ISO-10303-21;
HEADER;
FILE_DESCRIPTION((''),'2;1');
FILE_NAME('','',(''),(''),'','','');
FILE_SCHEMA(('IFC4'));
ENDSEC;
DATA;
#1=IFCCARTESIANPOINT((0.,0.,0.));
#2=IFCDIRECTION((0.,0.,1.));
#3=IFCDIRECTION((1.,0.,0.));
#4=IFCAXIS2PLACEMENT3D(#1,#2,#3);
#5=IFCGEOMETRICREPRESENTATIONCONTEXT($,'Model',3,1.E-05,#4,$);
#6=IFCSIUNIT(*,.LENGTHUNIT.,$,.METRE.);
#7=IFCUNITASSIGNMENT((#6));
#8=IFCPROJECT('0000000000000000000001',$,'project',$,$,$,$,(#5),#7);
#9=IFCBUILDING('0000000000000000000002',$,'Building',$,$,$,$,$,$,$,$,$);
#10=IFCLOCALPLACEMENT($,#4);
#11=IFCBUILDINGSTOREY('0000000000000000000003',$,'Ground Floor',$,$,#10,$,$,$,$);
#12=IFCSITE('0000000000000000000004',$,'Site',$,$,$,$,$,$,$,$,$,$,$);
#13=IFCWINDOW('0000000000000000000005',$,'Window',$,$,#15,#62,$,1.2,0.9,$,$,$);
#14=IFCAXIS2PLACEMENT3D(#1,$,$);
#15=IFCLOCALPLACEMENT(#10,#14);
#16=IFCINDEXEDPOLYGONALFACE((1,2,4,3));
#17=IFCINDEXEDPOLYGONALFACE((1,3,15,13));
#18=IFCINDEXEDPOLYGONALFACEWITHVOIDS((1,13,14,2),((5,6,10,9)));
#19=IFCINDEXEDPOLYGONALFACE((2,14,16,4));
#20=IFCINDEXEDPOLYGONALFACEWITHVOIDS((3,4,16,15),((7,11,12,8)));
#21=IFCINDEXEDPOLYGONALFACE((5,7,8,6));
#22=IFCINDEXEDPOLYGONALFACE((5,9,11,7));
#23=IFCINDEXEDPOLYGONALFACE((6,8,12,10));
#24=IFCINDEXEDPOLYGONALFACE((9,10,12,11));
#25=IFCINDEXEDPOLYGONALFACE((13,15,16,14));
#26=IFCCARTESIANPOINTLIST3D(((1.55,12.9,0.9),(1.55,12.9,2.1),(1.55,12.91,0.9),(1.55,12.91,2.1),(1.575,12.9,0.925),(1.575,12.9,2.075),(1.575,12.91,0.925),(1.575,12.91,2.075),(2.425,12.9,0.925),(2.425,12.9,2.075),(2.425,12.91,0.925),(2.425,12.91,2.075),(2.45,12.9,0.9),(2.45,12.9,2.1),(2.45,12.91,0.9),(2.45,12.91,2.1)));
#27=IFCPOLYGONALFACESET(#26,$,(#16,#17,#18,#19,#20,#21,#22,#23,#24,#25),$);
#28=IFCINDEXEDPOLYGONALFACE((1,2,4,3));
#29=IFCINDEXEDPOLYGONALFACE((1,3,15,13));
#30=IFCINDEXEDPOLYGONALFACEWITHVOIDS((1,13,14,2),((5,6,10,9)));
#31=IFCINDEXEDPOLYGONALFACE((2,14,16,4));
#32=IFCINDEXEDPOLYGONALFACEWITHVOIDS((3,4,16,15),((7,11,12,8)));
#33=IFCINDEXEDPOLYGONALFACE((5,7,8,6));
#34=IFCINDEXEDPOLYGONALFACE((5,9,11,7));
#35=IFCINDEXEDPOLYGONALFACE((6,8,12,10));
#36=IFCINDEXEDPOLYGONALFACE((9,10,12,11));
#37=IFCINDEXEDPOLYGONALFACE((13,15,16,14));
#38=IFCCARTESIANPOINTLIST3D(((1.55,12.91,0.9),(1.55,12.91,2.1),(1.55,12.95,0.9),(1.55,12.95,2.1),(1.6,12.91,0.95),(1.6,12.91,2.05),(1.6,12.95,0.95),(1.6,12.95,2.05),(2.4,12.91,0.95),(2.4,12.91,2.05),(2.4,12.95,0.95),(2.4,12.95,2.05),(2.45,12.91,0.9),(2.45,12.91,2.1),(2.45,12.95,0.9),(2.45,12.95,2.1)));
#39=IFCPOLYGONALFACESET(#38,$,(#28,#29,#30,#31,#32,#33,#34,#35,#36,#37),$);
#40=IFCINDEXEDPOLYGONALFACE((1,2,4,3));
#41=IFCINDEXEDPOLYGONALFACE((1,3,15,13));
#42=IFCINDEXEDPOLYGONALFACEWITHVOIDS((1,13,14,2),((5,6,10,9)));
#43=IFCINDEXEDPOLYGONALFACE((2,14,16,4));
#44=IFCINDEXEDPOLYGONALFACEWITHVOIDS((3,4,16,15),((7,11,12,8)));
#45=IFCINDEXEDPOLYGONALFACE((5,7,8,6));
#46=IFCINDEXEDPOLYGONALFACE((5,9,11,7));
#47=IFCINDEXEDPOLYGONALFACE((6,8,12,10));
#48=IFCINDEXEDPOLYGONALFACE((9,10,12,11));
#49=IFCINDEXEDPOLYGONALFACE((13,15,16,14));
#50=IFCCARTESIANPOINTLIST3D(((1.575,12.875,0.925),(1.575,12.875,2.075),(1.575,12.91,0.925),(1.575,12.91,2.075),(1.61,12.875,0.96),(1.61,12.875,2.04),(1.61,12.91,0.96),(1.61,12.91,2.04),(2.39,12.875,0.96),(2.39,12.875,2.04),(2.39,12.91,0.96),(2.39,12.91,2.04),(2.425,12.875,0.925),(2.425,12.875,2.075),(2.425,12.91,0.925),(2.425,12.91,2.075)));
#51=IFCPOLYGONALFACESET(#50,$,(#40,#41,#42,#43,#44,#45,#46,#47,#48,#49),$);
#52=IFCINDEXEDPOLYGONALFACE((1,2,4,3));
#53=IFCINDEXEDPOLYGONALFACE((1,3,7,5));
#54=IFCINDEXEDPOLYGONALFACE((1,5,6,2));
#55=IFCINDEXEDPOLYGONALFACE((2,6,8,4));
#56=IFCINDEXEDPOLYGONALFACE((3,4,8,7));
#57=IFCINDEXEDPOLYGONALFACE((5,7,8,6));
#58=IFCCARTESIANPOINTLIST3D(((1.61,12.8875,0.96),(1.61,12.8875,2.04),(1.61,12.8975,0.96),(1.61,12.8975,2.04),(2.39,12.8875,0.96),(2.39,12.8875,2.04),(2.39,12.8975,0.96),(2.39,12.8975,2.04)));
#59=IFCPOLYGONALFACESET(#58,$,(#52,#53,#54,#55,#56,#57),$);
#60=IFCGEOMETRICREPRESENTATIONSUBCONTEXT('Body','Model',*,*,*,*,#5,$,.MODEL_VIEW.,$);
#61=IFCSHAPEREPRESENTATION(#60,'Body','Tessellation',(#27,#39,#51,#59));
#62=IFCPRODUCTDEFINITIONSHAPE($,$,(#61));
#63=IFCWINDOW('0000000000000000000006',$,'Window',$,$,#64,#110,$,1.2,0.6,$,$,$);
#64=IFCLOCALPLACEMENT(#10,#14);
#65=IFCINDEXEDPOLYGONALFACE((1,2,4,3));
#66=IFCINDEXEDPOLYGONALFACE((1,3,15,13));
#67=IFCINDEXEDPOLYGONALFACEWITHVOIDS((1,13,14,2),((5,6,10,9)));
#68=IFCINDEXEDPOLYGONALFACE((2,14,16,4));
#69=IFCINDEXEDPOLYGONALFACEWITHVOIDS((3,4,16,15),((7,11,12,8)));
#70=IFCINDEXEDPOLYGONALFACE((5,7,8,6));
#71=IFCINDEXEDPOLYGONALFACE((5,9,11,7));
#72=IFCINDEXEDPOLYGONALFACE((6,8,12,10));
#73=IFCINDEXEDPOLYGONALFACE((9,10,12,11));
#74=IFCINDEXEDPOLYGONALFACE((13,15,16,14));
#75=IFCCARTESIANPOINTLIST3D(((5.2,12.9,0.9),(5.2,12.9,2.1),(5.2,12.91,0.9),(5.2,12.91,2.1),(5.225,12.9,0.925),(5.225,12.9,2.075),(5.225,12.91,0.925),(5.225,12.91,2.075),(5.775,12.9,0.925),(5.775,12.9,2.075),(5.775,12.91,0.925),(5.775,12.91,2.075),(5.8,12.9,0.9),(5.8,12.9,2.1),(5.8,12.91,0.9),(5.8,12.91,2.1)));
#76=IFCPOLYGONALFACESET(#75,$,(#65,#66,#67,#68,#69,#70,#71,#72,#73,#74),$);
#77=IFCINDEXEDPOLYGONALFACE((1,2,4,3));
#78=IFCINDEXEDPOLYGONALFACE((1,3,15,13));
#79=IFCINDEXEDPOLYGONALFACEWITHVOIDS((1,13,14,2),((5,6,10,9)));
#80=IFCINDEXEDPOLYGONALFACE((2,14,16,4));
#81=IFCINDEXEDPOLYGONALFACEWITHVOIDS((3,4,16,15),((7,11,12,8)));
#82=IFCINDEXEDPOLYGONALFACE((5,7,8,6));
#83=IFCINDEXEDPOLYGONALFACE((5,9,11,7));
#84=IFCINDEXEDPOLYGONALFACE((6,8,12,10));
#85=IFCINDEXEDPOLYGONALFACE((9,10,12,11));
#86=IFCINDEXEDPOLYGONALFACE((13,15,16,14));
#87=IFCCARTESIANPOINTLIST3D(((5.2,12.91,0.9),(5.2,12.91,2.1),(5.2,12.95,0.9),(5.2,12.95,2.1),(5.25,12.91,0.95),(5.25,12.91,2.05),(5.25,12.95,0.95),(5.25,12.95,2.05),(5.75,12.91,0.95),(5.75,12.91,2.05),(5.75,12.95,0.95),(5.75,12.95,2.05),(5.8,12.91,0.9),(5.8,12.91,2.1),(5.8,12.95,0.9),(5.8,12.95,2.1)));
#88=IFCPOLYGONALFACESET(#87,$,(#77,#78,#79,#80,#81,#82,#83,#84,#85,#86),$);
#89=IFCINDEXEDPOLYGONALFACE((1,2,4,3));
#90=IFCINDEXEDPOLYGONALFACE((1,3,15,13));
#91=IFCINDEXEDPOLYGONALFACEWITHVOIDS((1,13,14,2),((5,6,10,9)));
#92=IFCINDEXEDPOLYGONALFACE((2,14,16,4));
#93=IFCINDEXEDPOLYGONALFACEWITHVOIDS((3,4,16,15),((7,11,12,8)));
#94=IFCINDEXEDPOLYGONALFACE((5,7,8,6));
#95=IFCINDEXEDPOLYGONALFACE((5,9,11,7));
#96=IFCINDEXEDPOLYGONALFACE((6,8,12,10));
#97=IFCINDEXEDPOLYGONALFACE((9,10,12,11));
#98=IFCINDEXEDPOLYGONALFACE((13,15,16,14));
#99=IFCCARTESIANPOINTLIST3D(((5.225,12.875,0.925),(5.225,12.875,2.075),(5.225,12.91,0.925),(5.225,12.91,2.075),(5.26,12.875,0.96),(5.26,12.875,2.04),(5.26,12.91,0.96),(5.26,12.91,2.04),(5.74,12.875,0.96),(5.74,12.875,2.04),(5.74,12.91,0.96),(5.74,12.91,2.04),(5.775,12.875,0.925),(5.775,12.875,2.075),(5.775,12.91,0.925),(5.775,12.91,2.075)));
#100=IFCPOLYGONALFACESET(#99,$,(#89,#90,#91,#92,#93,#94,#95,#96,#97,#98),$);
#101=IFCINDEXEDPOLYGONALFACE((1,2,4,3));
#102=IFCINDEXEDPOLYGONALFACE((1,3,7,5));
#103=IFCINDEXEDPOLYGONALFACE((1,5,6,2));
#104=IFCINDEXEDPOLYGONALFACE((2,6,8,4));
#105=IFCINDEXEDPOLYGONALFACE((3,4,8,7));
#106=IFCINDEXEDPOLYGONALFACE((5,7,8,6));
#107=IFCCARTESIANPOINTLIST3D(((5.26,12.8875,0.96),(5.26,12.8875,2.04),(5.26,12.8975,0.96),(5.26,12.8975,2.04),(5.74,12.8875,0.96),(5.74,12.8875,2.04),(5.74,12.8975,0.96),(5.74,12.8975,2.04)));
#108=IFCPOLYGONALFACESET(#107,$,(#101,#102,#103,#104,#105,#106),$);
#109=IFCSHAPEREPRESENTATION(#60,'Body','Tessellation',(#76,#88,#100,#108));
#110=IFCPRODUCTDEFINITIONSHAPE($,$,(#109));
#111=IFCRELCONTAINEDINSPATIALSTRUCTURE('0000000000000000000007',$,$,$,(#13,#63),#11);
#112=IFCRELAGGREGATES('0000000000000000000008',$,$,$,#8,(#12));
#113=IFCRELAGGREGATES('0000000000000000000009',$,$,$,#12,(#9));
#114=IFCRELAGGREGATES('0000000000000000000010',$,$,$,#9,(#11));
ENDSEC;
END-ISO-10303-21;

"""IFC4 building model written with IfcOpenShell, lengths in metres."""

from ifc_helpers import new_model, si_unit, frame, origin_with_axes, place, context, subcontext, project, spatial, line, indexed_curve, outline, extrude, element, save


model = new_model("IFC4")

# Units and contexts
model_context = context("Model", 3, precision=1e-05, world=origin_with_axes())
body_context = subcontext(model_context, "Body", "Model", "MODEL_VIEW")
ifc_project = project(units=[si_unit("LENGTHUNIT", "METRE")], contexts=[model_context])

# Site, building, storey
site = spatial("IfcSite", under=ifc_project, Name="Site")
building = spatial("IfcBuilding", under=site, Name="Building")
storey_placement = place(None, origin_with_axes())
storey = spatial("IfcBuildingStorey", under=building, at=storey_placement, Name="Ground Floor")

# Windows
for number, where, z_axis, x_axis, name in (
    (1, (2.45, 13.0, 0.9), (0.0, 0.0, 1.0), (-1.0, 0.0, 0.0), "Window"),
):
    element("IfcWindow", number, at=place(storey_placement, frame(where, z_axis=z_axis, x_axis=x_axis)), inside=storey, Name=name, OverallHeight=1.2, OverallWidth=0.9, context=body_context, shape_type="SweptSolid", body=[
        extrude(outline(indexed_curve([(0.0, 0.0), (0.9, 0.0), (0.9, 1.2), (0.0, 1.2)], segments=[line(1, 2, 3, 4, 1)]), holes=[indexed_curve([(0.025, 0.025), (0.875, 0.025), (0.875, 1.175), (0.025, 1.175)], segments=[line(1, 2, 3, 4, 1)])]), frame((0.0, 0.09, 0.0), z_axis=(0.0, -1.0, 0.0), x_axis=(1.0, 0.0, 0.0)), (0.0, 0.0, -1.0), 0.01),
        extrude(outline(indexed_curve([(0.0, 0.0), (0.9, 0.0), (0.9, 1.2), (0.0, 1.2)], segments=[line(1, 2, 3, 4, 1)]), holes=[indexed_curve([(0.05, 0.05), (0.85, 0.05), (0.85, 1.15), (0.05, 1.15)], segments=[line(1, 2, 3, 4, 1)])]), frame((0.0, 0.05, 0.0), z_axis=(0.0, -1.0, 0.0), x_axis=(1.0, 0.0, 0.0)), (0.0, 0.0, -1.0), 0.04),
        extrude(outline(indexed_curve([(0.0, 0.0), (0.85, 0.0), (0.85, 1.15), (0.0, 1.15)], segments=[line(1, 2, 3, 4, 1)]), holes=[indexed_curve([(0.035, 0.035), (0.815, 0.035), (0.815, 1.115), (0.035, 1.115)], segments=[line(1, 2, 3, 4, 1)])]), frame((0.025, 0.09, 0.025), z_axis=(0.0, -1.0, 0.0), x_axis=(1.0, 0.0, 0.0)), (0.0, 0.0, -1.0), 0.035),
        extrude(outline(indexed_curve([(0.035, 0.035), (0.815, 0.035), (0.815, 1.115), (0.035, 1.115)], segments=[line(1, 2, 3, 4, 1)])), frame((0.025, 0.1025, 0.025), z_axis=(0.0, -1.0, 0.0), x_axis=(1.0, 0.0, 0.0)), (0.0, 0.0, -1.0), 0.01),
    ])
window_placement = place(storey_placement, frame((5.8, 13.0, 0.9), z_axis=(0.0, 0.0, 1.0), x_axis=(-1.0, 0.0, 0.0)))
element("IfcWindow", 2, at=window_placement, inside=storey, Name="Window", OverallHeight=1.2, OverallWidth=0.6, context=body_context, shape_type="SweptSolid", body=[
    extrude(outline(indexed_curve([(0.0, 0.0), (0.6, 0.0), (0.6, 1.2), (0.0, 1.2)], segments=[line(1, 2, 3, 4, 1)]), holes=[indexed_curve([(0.025, 0.025), (0.575, 0.025), (0.575, 1.175), (0.025, 1.175)], segments=[line(1, 2, 3, 4, 1)])]), frame((0.0, 0.09, 0.0), z_axis=(0.0, -1.0, 0.0), x_axis=(1.0, 0.0, 0.0)), (0.0, 0.0, -1.0), 0.01),
    extrude(outline(indexed_curve([(0.0, 0.0), (0.6, 0.0), (0.6, 1.2), (0.0, 1.2)], segments=[line(1, 2, 3, 4, 1)]), holes=[indexed_curve([(0.05, 0.05), (0.55, 0.05), (0.55, 1.15), (0.05, 1.15)], segments=[line(1, 2, 3, 4, 1)])]), frame((0.0, 0.05, 0.0), z_axis=(0.0, -1.0, 0.0), x_axis=(1.0, 0.0, 0.0)), (0.0, 0.0, -1.0), 0.04),
    extrude(outline(indexed_curve([(0.0, 0.0), (0.55, 0.0), (0.55, 1.15), (0.0, 1.15)], segments=[line(1, 2, 3, 4, 1)]), holes=[indexed_curve([(0.035, 0.035), (0.515, 0.035), (0.515, 1.115), (0.035, 1.115)], segments=[line(1, 2, 3, 4, 1)])]), frame((0.025, 0.09, 0.025), z_axis=(0.0, -1.0, 0.0), x_axis=(1.0, 0.0, 0.0)), (0.0, 0.0, -1.0), 0.035),
    extrude(outline(indexed_curve([(0.035, 0.035), (0.515, 0.035), (0.515, 1.115), (0.035, 1.115)], segments=[line(1, 2, 3, 4, 1)])), frame((0.025, 0.1025, 0.025), z_axis=(0.0, -1.0, 0.0), x_axis=(1.0, 0.0, 0.0)), (0.0, 0.0, -1.0), 0.01),
])

save(model, "model.ifc")
